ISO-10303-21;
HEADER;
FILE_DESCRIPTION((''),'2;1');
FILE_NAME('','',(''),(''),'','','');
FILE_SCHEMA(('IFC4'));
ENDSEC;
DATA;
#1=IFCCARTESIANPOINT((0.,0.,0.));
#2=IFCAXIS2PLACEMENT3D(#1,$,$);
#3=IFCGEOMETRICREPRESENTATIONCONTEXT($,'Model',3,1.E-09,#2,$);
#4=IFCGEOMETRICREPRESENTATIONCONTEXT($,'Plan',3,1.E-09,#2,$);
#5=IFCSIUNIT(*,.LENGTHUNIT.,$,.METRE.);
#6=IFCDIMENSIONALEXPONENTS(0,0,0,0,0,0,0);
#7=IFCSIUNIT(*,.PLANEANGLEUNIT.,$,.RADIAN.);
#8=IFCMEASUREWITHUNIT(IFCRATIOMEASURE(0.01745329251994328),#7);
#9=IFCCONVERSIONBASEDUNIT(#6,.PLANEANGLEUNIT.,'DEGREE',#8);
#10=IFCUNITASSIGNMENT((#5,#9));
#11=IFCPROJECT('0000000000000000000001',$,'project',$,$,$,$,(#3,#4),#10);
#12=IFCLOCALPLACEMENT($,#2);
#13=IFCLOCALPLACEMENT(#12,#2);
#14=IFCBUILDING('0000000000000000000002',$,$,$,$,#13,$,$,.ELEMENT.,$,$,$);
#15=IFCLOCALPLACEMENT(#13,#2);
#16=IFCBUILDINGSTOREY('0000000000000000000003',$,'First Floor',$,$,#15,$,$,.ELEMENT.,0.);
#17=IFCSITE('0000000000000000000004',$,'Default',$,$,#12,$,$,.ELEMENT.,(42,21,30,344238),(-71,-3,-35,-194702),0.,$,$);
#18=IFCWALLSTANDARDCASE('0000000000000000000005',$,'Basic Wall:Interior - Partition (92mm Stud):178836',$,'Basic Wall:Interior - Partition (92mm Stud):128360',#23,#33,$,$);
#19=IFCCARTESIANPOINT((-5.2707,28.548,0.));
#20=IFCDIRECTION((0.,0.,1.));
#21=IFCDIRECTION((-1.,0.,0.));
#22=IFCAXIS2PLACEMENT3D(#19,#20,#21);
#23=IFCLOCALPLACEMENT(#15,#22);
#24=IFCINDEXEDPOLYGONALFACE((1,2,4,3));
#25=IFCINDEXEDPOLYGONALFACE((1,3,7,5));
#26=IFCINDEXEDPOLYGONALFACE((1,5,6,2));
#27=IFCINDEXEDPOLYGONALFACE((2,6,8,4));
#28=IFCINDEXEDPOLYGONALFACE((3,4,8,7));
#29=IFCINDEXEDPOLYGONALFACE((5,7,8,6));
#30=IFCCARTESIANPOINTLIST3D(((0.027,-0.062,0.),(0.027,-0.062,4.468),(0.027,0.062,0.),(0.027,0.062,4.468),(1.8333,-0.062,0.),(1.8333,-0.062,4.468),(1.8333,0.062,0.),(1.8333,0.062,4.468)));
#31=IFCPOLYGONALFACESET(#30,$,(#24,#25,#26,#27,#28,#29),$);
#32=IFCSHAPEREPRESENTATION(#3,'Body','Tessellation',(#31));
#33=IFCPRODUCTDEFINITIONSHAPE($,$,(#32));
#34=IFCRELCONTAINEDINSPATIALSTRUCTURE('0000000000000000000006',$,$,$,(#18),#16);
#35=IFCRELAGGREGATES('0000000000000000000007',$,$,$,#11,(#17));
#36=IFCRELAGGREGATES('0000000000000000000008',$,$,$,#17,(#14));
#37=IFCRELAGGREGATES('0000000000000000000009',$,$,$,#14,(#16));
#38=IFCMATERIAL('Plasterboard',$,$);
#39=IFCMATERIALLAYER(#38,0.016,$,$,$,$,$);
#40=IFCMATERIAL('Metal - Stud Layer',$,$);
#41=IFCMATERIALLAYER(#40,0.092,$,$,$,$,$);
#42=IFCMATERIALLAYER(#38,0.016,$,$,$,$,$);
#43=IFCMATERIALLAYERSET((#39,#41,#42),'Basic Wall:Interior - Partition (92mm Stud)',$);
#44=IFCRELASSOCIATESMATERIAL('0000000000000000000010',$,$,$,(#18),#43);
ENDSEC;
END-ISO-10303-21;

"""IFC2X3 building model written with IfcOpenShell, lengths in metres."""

from ifc_helpers import new_model, entity, si_unit, converted_unit, frame, frame_2d, origin, place, context, project, spatial, rectangle, extrude, material, layer, layer_set, layer_usage, element, save


model = new_model("IFC2X3")

# Units and contexts
model_context = context("Model", 3, precision=1e-09, world=origin())
plan_context = context("Plan", 3, precision=1e-09, world=origin())
ifc_project = project(units=[si_unit("LENGTHUNIT", "METRE"), converted_unit("PLANEANGLEUNIT", "DEGREE", entity("IfcRatioMeasure", 0.01745329251994328), si_unit("PLANEANGLEUNIT", "RADIAN"), dimensions=[0, 0, 0, 0, 0, 0, 0])], contexts=[model_context, plan_context])

# Site, building, storey
site_placement = place(None, origin())
site = spatial("IfcSite", under=ifc_project, at=site_placement, Name="Default", CompositionType="ELEMENT", RefLatitude=(42, 21, 30, 344238), RefLongitude=(-71, -3, -35, -194702), RefElevation=0.0)
building_placement = place(site_placement, origin())
building = spatial("IfcBuilding", under=site, at=building_placement, CompositionType="ELEMENT")
storey_placement = place(building_placement, origin())
storey = spatial("IfcBuildingStorey", under=building, at=storey_placement, Name="First Floor", CompositionType="ELEMENT", Elevation=0.0)

# Shared definitions
ifc_material_1 = material(Name="Plasterboard")
ifc_layer_1 = layer(ifc_material_1, 0.016)
ifc_material_2 = material(Name="Metal - Stud Layer")
ifc_layer_2 = layer(ifc_material_2, 0.092)
ifc_layer_3 = layer(ifc_material_1, 0.016)
ifc_layer_set_1 = layer_set([ifc_layer_1, ifc_layer_2, ifc_layer_3], Name="Basic Wall:Interior - Partition (92mm Stud)")
ifc_layer_usage_1 = layer_usage(ifc_layer_set_1, "AXIS2", "NEGATIVE", 0.062)

# Wall
wall_1_placement = place(storey_placement, frame((-5.2707, 28.548, 0.0), z_axis=(0.0, 0.0, 1.0), x_axis=(-1.0, 0.0, 0.0)))
element("IfcWallStandardCase", 1, at=wall_1_placement, inside=storey, material=ifc_layer_usage_1, Name="Basic Wall:Interior - Partition (92mm Stud):178836", ObjectType="Basic Wall:Interior - Partition (92mm Stud):128360", context=model_context, shape_type="SweptSolid", body=[
    extrude(rectangle(XDim=1.8063, YDim=0.124, at=frame_2d((0.9301, 0.0), x_axis=(-1.0, 0.0))), origin(), (0.0, 0.0, 1.0), 4.468),
])

save(model, "model.ifc")
